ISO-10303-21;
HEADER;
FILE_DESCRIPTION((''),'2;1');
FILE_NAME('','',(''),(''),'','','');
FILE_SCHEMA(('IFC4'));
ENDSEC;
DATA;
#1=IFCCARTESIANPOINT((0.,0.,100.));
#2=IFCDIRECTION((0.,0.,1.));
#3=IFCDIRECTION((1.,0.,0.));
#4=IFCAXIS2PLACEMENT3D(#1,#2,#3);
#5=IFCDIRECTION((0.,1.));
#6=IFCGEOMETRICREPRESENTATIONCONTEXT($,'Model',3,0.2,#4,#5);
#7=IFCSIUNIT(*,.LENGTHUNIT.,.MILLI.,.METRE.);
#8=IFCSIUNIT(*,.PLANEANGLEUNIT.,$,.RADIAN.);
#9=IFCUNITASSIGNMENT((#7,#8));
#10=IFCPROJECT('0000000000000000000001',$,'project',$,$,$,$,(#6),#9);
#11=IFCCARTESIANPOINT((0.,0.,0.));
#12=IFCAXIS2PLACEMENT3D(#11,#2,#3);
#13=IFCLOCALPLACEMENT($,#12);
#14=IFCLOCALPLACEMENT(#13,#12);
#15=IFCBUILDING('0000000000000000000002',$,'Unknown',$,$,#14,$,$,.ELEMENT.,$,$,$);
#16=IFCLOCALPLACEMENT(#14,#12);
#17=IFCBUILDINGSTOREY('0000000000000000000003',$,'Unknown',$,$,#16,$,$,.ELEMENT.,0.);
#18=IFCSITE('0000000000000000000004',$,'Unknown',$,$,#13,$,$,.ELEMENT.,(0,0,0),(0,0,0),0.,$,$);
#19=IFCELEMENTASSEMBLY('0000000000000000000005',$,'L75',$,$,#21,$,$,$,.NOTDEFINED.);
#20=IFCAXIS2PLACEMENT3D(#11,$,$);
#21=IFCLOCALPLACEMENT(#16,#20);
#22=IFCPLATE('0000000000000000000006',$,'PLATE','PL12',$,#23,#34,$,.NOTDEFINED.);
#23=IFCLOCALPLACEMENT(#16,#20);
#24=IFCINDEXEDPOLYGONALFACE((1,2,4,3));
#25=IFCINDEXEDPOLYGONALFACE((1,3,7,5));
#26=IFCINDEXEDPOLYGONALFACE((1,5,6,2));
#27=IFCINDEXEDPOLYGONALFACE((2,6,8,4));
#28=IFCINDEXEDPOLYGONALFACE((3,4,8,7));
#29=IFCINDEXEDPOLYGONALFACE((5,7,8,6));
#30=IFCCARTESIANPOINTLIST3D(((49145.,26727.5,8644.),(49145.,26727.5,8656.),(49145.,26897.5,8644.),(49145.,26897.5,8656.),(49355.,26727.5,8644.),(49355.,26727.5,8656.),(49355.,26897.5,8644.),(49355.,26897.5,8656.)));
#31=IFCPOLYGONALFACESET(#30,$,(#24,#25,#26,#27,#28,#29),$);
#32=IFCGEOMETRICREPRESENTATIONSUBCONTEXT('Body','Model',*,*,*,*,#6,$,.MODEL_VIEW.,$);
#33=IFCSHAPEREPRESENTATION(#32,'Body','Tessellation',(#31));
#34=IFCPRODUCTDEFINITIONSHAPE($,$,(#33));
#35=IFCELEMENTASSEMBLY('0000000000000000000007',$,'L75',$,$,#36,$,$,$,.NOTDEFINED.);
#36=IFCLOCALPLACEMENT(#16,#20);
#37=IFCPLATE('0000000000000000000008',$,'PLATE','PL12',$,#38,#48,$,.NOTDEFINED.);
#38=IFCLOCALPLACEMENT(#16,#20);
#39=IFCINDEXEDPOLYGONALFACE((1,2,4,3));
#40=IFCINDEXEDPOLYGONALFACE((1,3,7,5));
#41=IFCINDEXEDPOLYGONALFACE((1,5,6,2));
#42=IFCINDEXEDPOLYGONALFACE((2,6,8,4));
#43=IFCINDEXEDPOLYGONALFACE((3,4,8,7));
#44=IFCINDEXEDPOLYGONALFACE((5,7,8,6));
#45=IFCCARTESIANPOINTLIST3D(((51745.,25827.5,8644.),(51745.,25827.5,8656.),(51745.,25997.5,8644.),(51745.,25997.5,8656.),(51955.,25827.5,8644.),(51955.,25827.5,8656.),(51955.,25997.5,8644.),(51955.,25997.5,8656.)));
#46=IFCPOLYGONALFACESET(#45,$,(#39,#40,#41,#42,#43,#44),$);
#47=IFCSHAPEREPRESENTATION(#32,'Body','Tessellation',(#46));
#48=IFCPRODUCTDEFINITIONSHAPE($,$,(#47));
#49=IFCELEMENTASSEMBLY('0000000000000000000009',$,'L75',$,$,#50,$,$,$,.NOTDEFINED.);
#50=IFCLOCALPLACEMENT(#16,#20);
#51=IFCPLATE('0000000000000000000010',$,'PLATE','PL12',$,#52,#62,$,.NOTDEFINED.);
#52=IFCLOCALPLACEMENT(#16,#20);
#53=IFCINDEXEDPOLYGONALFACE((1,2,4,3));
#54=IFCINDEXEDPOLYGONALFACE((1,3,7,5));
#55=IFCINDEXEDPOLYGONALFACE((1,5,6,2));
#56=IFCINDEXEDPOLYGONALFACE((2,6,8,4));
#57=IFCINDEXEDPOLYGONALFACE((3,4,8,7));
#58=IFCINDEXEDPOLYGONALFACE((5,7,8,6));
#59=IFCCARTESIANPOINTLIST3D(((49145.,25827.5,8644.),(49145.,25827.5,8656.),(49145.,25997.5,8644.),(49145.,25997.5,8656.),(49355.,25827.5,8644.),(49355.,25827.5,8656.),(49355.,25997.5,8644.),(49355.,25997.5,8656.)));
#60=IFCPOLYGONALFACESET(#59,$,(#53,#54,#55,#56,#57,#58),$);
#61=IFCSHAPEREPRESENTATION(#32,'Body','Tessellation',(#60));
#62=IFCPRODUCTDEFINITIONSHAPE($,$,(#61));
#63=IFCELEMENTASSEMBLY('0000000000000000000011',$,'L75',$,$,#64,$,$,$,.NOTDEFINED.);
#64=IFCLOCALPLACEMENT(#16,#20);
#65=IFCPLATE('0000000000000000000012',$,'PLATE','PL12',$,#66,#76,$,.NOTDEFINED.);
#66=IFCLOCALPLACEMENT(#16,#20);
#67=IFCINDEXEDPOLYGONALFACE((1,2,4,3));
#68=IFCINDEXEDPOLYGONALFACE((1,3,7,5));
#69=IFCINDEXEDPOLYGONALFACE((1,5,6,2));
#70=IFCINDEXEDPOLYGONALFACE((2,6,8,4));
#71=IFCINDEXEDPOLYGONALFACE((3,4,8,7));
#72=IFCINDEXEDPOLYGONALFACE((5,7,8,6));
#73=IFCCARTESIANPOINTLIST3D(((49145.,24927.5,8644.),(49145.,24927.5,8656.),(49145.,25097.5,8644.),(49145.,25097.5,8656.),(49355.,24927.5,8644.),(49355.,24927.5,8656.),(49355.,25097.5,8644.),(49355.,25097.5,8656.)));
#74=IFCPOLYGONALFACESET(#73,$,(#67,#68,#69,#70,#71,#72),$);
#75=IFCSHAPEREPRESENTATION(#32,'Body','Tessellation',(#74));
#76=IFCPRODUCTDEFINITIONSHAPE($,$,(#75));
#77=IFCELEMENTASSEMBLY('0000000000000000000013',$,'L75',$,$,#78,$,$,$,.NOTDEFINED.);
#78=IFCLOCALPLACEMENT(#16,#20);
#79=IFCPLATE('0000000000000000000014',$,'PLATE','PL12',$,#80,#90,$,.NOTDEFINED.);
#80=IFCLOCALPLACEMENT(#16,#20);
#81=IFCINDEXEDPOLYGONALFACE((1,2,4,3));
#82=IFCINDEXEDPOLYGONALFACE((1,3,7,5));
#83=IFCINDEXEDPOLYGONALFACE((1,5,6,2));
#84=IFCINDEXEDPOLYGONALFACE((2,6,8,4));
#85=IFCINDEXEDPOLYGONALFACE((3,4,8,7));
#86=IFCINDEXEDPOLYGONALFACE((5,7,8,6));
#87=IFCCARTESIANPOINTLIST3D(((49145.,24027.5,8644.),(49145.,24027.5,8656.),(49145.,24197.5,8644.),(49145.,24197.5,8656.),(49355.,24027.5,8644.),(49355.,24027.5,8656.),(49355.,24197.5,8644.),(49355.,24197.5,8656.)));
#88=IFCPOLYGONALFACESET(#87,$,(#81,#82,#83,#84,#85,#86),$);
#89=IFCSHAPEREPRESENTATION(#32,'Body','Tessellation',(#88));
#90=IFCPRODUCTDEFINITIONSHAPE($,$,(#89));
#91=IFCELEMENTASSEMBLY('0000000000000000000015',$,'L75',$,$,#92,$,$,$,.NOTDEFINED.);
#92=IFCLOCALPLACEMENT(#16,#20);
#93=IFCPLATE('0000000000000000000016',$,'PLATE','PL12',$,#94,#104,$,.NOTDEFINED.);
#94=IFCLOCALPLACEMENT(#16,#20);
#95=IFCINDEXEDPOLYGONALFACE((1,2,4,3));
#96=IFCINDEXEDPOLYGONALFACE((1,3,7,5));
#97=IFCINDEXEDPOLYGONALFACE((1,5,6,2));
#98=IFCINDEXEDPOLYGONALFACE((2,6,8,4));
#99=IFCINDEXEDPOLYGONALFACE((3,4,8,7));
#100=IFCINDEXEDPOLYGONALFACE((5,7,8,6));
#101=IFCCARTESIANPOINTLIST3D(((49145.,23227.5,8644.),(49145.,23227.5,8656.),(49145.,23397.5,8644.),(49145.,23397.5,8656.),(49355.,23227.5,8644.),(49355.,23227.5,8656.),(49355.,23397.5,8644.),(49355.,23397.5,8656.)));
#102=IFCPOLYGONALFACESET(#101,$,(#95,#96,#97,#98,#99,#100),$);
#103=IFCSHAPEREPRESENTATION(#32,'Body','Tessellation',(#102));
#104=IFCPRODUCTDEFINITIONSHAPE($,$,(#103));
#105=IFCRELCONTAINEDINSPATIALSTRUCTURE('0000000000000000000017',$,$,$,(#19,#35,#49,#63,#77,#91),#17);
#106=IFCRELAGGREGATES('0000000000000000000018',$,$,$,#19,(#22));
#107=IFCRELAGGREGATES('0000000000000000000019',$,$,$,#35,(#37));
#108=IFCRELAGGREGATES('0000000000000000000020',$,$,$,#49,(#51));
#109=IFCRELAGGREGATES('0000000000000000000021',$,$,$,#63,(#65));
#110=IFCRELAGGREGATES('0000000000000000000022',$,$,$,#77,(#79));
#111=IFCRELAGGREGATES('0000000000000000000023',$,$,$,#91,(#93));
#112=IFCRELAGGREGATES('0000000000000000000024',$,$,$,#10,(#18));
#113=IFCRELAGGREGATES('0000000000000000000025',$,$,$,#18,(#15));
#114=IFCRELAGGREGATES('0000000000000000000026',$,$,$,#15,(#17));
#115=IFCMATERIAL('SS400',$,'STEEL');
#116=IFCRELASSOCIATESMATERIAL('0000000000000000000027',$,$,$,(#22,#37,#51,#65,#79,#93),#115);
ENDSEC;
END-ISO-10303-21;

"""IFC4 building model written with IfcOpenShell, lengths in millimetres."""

from ifc_helpers import new_model, si_unit, direction, frame, origin_with_axes, place, context, subcontext, project, spatial, line, indexed_curve, outline, extrude, material, element, aggregate, save


model = new_model("IFC4")

# Units and contexts
model_context = context("Model", 3, precision=0.2, world=frame((0.0, 0.0, 100.0), z_axis=(0.0, 0.0, 1.0), x_axis=(1.0, 0.0, 0.0)), true_north=direction((0.0, 1.0)))
body_context = subcontext(model_context, "Body", "Model", "MODEL_VIEW")
ifc_project = project(units=[si_unit("LENGTHUNIT", "METRE", prefix="MILLI"), si_unit("PLANEANGLEUNIT", "RADIAN")], contexts=[model_context])

# Site, building, storey
site_placement = place(None, origin_with_axes())
site = spatial("IfcSite", under=ifc_project, at=site_placement, Name="Unknown", CompositionType="ELEMENT", RefLatitude=(0, 0, 0), RefLongitude=(0, 0, 0), RefElevation=0.0)
building_placement = place(site_placement, origin_with_axes())
building = spatial("IfcBuilding", under=site, at=building_placement, Name="Unknown", CompositionType="ELEMENT")
storey_placement = place(building_placement, origin_with_axes())
storey = spatial("IfcBuildingStorey", under=building, at=storey_placement, Name="Unknown", CompositionType="ELEMENT", Elevation=0.0)

# Shared definitions
ifc_material_1 = material(Name="SS400", Category="STEEL")

# Element assemblies, plates
assembly_1_placement = place(storey_placement, frame((49250.0, 26812.5, 8355.0), z_axis=(0.0, -1.0, 0.0), x_axis=(0.0, 0.0, 1.0)))
assembly_1 = element("IfcElementAssembly", 1, at=assembly_1_placement, inside=storey, Name="L75", PredefinedType="NOTDEFINED")
plate_1_placement = place(assembly_1_placement, frame((295.0, -105.0, 85.0), z_axis=(1.0, 0.0, 0.0), x_axis=(0.0, 0.0, -1.0)))
plate_1 = element("IfcPlate", 2, at=plate_1_placement, material=ifc_material_1, Name="PLATE", Description="PL12", PredefinedType="NOTDEFINED", context=body_context, shape_type="SolidModel", body=[
    extrude(outline(indexed_curve([(0.0, 0.0), (170.0, 0.0), (170.0, 210.0), (0.0, 210.0)], segments=[line(1, 2, 3, 4, 1)])), frame((0.0, 0.0, 6.0), z_axis=(0.0, 0.0, 1.0), x_axis=(1.0, 0.0, 0.0)), (0.0, 0.0, -1.0), 12.0),
])
aggregate(assembly_1, [plate_1])
assembly_2_placement = place(storey_placement, frame((51850.0, 25912.5, 8355.0), z_axis=(0.0, -1.0, 0.0), x_axis=(0.0, 0.0, 1.0)))
assembly_2 = element("IfcElementAssembly", 3, at=assembly_2_placement, inside=storey, Name="L75", PredefinedType="NOTDEFINED")
plate_2_placement = place(assembly_2_placement, frame((295.0, -105.0, 85.0), z_axis=(1.0, 0.0, 0.0), x_axis=(0.0, 0.0, -1.0)))
plate_2 = element("IfcPlate", 4, at=plate_2_placement, material=ifc_material_1, Name="PLATE", Description="PL12", PredefinedType="NOTDEFINED", context=body_context, shape_type="SolidModel", body=[
    extrude(outline(indexed_curve([(0.0, 0.0), (170.0, 0.0), (170.0, 210.0), (0.0, 210.0)], segments=[line(1, 2, 3, 4, 1)])), frame((0.0, 0.0, 6.0), z_axis=(0.0, 0.0, 1.0), x_axis=(1.0, 0.0, 0.0)), (0.0, 0.0, -1.0), 12.0),
])
aggregate(assembly_2, [plate_2])
assembly_3_placement = place(storey_placement, frame((49250.0, 25912.5, 8355.0), z_axis=(0.0, -1.0, 0.0), x_axis=(0.0, 0.0, 1.0)))
assembly_3 = element("IfcElementAssembly", 5, at=assembly_3_placement, inside=storey, Name="L75", PredefinedType="NOTDEFINED")
plate_3_placement = place(assembly_3_placement, frame((295.0, -105.0, 85.0), z_axis=(1.0, 0.0, 0.0), x_axis=(0.0, 0.0, -1.0)))
plate_3 = element("IfcPlate", 6, at=plate_3_placement, material=ifc_material_1, Name="PLATE", Description="PL12", PredefinedType="NOTDEFINED", context=body_context, shape_type="SolidModel", body=[
    extrude(outline(indexed_curve([(0.0, 0.0), (170.0, 0.0), (170.0, 210.0), (0.0, 210.0)], segments=[line(1, 2, 3, 4, 1)])), frame((0.0, 0.0, 6.0), z_axis=(0.0, 0.0, 1.0), x_axis=(1.0, 0.0, 0.0)), (0.0, 0.0, -1.0), 12.0),
])
aggregate(assembly_3, [plate_3])
assembly_4_placement = place(storey_placement, frame((49250.0, 25012.5, 8355.0), z_axis=(0.0, -1.0, 0.0), x_axis=(0.0, 0.0, 1.0)))
assembly_4 = element("IfcElementAssembly", 7, at=assembly_4_placement, inside=storey, Name="L75", PredefinedType="NOTDEFINED")
plate_4_placement = place(assembly_4_placement, frame((295.0, -105.0, 85.0), z_axis=(1.0, 0.0, 0.0), x_axis=(0.0, 0.0, -1.0)))
plate_4 = element("IfcPlate", 8, at=plate_4_placement, material=ifc_material_1, Name="PLATE", Description="PL12", PredefinedType="NOTDEFINED", context=body_context, shape_type="SolidModel", body=[
    extrude(outline(indexed_curve([(0.0, 0.0), (170.0, 0.0), (170.0, 210.0), (0.0, 210.0)], segments=[line(1, 2, 3, 4, 1)])), frame((0.0, 0.0, 6.0), z_axis=(0.0, 0.0, 1.0), x_axis=(1.0, 0.0, 0.0)), (0.0, 0.0, -1.0), 12.0),
])
aggregate(assembly_4, [plate_4])
assembly_5_placement = place(storey_placement, frame((49250.0, 24112.5, 8355.0), z_axis=(0.0, -1.0, 0.0), x_axis=(0.0, 0.0, 1.0)))
assembly_5 = element("IfcElementAssembly", 9, at=assembly_5_placement, inside=storey, Name="L75", PredefinedType="NOTDEFINED")
plate_5_placement = place(assembly_5_placement, frame((295.0, -105.0, 85.0), z_axis=(1.0, 0.0, 0.0), x_axis=(0.0, 0.0, -1.0)))
plate_5 = element("IfcPlate", 10, at=plate_5_placement, material=ifc_material_1, Name="PLATE", Description="PL12", PredefinedType="NOTDEFINED", context=body_context, shape_type="SolidModel", body=[
    extrude(outline(indexed_curve([(0.0, 0.0), (170.0, 0.0), (170.0, 210.0), (0.0, 210.0)], segments=[line(1, 2, 3, 4, 1)])), frame((0.0, 0.0, 6.0), z_axis=(0.0, 0.0, 1.0), x_axis=(1.0, 0.0, 0.0)), (0.0, 0.0, -1.0), 12.0),
])
aggregate(assembly_5, [plate_5])
assembly_6_placement = place(storey_placement, frame((49250.0, 23312.5, 8355.0), z_axis=(0.0, -1.0, 0.0), x_axis=(0.0, 0.0, 1.0)))
assembly_6 = element("IfcElementAssembly", 11, at=assembly_6_placement, inside=storey, Name="L75", PredefinedType="NOTDEFINED")
plate_6_placement = place(assembly_6_placement, frame((295.0, -105.0, 85.0), z_axis=(1.0, 0.0, 0.0), x_axis=(0.0, 0.0, -1.0)))
plate_6 = element("IfcPlate", 12, at=plate_6_placement, material=ifc_material_1, Name="PLATE", Description="PL12", PredefinedType="NOTDEFINED", context=body_context, shape_type="SolidModel", body=[
    extrude(outline(indexed_curve([(0.0, 0.0), (170.0, 0.0), (170.0, 210.0), (0.0, 210.0)], segments=[line(1, 2, 3, 4, 1)])), frame((0.0, 0.0, 6.0), z_axis=(0.0, 0.0, 1.0), x_axis=(1.0, 0.0, 0.0)), (0.0, 0.0, -1.0), 12.0),
])
aggregate(assembly_6, [plate_6])

save(model, "model.ifc")
